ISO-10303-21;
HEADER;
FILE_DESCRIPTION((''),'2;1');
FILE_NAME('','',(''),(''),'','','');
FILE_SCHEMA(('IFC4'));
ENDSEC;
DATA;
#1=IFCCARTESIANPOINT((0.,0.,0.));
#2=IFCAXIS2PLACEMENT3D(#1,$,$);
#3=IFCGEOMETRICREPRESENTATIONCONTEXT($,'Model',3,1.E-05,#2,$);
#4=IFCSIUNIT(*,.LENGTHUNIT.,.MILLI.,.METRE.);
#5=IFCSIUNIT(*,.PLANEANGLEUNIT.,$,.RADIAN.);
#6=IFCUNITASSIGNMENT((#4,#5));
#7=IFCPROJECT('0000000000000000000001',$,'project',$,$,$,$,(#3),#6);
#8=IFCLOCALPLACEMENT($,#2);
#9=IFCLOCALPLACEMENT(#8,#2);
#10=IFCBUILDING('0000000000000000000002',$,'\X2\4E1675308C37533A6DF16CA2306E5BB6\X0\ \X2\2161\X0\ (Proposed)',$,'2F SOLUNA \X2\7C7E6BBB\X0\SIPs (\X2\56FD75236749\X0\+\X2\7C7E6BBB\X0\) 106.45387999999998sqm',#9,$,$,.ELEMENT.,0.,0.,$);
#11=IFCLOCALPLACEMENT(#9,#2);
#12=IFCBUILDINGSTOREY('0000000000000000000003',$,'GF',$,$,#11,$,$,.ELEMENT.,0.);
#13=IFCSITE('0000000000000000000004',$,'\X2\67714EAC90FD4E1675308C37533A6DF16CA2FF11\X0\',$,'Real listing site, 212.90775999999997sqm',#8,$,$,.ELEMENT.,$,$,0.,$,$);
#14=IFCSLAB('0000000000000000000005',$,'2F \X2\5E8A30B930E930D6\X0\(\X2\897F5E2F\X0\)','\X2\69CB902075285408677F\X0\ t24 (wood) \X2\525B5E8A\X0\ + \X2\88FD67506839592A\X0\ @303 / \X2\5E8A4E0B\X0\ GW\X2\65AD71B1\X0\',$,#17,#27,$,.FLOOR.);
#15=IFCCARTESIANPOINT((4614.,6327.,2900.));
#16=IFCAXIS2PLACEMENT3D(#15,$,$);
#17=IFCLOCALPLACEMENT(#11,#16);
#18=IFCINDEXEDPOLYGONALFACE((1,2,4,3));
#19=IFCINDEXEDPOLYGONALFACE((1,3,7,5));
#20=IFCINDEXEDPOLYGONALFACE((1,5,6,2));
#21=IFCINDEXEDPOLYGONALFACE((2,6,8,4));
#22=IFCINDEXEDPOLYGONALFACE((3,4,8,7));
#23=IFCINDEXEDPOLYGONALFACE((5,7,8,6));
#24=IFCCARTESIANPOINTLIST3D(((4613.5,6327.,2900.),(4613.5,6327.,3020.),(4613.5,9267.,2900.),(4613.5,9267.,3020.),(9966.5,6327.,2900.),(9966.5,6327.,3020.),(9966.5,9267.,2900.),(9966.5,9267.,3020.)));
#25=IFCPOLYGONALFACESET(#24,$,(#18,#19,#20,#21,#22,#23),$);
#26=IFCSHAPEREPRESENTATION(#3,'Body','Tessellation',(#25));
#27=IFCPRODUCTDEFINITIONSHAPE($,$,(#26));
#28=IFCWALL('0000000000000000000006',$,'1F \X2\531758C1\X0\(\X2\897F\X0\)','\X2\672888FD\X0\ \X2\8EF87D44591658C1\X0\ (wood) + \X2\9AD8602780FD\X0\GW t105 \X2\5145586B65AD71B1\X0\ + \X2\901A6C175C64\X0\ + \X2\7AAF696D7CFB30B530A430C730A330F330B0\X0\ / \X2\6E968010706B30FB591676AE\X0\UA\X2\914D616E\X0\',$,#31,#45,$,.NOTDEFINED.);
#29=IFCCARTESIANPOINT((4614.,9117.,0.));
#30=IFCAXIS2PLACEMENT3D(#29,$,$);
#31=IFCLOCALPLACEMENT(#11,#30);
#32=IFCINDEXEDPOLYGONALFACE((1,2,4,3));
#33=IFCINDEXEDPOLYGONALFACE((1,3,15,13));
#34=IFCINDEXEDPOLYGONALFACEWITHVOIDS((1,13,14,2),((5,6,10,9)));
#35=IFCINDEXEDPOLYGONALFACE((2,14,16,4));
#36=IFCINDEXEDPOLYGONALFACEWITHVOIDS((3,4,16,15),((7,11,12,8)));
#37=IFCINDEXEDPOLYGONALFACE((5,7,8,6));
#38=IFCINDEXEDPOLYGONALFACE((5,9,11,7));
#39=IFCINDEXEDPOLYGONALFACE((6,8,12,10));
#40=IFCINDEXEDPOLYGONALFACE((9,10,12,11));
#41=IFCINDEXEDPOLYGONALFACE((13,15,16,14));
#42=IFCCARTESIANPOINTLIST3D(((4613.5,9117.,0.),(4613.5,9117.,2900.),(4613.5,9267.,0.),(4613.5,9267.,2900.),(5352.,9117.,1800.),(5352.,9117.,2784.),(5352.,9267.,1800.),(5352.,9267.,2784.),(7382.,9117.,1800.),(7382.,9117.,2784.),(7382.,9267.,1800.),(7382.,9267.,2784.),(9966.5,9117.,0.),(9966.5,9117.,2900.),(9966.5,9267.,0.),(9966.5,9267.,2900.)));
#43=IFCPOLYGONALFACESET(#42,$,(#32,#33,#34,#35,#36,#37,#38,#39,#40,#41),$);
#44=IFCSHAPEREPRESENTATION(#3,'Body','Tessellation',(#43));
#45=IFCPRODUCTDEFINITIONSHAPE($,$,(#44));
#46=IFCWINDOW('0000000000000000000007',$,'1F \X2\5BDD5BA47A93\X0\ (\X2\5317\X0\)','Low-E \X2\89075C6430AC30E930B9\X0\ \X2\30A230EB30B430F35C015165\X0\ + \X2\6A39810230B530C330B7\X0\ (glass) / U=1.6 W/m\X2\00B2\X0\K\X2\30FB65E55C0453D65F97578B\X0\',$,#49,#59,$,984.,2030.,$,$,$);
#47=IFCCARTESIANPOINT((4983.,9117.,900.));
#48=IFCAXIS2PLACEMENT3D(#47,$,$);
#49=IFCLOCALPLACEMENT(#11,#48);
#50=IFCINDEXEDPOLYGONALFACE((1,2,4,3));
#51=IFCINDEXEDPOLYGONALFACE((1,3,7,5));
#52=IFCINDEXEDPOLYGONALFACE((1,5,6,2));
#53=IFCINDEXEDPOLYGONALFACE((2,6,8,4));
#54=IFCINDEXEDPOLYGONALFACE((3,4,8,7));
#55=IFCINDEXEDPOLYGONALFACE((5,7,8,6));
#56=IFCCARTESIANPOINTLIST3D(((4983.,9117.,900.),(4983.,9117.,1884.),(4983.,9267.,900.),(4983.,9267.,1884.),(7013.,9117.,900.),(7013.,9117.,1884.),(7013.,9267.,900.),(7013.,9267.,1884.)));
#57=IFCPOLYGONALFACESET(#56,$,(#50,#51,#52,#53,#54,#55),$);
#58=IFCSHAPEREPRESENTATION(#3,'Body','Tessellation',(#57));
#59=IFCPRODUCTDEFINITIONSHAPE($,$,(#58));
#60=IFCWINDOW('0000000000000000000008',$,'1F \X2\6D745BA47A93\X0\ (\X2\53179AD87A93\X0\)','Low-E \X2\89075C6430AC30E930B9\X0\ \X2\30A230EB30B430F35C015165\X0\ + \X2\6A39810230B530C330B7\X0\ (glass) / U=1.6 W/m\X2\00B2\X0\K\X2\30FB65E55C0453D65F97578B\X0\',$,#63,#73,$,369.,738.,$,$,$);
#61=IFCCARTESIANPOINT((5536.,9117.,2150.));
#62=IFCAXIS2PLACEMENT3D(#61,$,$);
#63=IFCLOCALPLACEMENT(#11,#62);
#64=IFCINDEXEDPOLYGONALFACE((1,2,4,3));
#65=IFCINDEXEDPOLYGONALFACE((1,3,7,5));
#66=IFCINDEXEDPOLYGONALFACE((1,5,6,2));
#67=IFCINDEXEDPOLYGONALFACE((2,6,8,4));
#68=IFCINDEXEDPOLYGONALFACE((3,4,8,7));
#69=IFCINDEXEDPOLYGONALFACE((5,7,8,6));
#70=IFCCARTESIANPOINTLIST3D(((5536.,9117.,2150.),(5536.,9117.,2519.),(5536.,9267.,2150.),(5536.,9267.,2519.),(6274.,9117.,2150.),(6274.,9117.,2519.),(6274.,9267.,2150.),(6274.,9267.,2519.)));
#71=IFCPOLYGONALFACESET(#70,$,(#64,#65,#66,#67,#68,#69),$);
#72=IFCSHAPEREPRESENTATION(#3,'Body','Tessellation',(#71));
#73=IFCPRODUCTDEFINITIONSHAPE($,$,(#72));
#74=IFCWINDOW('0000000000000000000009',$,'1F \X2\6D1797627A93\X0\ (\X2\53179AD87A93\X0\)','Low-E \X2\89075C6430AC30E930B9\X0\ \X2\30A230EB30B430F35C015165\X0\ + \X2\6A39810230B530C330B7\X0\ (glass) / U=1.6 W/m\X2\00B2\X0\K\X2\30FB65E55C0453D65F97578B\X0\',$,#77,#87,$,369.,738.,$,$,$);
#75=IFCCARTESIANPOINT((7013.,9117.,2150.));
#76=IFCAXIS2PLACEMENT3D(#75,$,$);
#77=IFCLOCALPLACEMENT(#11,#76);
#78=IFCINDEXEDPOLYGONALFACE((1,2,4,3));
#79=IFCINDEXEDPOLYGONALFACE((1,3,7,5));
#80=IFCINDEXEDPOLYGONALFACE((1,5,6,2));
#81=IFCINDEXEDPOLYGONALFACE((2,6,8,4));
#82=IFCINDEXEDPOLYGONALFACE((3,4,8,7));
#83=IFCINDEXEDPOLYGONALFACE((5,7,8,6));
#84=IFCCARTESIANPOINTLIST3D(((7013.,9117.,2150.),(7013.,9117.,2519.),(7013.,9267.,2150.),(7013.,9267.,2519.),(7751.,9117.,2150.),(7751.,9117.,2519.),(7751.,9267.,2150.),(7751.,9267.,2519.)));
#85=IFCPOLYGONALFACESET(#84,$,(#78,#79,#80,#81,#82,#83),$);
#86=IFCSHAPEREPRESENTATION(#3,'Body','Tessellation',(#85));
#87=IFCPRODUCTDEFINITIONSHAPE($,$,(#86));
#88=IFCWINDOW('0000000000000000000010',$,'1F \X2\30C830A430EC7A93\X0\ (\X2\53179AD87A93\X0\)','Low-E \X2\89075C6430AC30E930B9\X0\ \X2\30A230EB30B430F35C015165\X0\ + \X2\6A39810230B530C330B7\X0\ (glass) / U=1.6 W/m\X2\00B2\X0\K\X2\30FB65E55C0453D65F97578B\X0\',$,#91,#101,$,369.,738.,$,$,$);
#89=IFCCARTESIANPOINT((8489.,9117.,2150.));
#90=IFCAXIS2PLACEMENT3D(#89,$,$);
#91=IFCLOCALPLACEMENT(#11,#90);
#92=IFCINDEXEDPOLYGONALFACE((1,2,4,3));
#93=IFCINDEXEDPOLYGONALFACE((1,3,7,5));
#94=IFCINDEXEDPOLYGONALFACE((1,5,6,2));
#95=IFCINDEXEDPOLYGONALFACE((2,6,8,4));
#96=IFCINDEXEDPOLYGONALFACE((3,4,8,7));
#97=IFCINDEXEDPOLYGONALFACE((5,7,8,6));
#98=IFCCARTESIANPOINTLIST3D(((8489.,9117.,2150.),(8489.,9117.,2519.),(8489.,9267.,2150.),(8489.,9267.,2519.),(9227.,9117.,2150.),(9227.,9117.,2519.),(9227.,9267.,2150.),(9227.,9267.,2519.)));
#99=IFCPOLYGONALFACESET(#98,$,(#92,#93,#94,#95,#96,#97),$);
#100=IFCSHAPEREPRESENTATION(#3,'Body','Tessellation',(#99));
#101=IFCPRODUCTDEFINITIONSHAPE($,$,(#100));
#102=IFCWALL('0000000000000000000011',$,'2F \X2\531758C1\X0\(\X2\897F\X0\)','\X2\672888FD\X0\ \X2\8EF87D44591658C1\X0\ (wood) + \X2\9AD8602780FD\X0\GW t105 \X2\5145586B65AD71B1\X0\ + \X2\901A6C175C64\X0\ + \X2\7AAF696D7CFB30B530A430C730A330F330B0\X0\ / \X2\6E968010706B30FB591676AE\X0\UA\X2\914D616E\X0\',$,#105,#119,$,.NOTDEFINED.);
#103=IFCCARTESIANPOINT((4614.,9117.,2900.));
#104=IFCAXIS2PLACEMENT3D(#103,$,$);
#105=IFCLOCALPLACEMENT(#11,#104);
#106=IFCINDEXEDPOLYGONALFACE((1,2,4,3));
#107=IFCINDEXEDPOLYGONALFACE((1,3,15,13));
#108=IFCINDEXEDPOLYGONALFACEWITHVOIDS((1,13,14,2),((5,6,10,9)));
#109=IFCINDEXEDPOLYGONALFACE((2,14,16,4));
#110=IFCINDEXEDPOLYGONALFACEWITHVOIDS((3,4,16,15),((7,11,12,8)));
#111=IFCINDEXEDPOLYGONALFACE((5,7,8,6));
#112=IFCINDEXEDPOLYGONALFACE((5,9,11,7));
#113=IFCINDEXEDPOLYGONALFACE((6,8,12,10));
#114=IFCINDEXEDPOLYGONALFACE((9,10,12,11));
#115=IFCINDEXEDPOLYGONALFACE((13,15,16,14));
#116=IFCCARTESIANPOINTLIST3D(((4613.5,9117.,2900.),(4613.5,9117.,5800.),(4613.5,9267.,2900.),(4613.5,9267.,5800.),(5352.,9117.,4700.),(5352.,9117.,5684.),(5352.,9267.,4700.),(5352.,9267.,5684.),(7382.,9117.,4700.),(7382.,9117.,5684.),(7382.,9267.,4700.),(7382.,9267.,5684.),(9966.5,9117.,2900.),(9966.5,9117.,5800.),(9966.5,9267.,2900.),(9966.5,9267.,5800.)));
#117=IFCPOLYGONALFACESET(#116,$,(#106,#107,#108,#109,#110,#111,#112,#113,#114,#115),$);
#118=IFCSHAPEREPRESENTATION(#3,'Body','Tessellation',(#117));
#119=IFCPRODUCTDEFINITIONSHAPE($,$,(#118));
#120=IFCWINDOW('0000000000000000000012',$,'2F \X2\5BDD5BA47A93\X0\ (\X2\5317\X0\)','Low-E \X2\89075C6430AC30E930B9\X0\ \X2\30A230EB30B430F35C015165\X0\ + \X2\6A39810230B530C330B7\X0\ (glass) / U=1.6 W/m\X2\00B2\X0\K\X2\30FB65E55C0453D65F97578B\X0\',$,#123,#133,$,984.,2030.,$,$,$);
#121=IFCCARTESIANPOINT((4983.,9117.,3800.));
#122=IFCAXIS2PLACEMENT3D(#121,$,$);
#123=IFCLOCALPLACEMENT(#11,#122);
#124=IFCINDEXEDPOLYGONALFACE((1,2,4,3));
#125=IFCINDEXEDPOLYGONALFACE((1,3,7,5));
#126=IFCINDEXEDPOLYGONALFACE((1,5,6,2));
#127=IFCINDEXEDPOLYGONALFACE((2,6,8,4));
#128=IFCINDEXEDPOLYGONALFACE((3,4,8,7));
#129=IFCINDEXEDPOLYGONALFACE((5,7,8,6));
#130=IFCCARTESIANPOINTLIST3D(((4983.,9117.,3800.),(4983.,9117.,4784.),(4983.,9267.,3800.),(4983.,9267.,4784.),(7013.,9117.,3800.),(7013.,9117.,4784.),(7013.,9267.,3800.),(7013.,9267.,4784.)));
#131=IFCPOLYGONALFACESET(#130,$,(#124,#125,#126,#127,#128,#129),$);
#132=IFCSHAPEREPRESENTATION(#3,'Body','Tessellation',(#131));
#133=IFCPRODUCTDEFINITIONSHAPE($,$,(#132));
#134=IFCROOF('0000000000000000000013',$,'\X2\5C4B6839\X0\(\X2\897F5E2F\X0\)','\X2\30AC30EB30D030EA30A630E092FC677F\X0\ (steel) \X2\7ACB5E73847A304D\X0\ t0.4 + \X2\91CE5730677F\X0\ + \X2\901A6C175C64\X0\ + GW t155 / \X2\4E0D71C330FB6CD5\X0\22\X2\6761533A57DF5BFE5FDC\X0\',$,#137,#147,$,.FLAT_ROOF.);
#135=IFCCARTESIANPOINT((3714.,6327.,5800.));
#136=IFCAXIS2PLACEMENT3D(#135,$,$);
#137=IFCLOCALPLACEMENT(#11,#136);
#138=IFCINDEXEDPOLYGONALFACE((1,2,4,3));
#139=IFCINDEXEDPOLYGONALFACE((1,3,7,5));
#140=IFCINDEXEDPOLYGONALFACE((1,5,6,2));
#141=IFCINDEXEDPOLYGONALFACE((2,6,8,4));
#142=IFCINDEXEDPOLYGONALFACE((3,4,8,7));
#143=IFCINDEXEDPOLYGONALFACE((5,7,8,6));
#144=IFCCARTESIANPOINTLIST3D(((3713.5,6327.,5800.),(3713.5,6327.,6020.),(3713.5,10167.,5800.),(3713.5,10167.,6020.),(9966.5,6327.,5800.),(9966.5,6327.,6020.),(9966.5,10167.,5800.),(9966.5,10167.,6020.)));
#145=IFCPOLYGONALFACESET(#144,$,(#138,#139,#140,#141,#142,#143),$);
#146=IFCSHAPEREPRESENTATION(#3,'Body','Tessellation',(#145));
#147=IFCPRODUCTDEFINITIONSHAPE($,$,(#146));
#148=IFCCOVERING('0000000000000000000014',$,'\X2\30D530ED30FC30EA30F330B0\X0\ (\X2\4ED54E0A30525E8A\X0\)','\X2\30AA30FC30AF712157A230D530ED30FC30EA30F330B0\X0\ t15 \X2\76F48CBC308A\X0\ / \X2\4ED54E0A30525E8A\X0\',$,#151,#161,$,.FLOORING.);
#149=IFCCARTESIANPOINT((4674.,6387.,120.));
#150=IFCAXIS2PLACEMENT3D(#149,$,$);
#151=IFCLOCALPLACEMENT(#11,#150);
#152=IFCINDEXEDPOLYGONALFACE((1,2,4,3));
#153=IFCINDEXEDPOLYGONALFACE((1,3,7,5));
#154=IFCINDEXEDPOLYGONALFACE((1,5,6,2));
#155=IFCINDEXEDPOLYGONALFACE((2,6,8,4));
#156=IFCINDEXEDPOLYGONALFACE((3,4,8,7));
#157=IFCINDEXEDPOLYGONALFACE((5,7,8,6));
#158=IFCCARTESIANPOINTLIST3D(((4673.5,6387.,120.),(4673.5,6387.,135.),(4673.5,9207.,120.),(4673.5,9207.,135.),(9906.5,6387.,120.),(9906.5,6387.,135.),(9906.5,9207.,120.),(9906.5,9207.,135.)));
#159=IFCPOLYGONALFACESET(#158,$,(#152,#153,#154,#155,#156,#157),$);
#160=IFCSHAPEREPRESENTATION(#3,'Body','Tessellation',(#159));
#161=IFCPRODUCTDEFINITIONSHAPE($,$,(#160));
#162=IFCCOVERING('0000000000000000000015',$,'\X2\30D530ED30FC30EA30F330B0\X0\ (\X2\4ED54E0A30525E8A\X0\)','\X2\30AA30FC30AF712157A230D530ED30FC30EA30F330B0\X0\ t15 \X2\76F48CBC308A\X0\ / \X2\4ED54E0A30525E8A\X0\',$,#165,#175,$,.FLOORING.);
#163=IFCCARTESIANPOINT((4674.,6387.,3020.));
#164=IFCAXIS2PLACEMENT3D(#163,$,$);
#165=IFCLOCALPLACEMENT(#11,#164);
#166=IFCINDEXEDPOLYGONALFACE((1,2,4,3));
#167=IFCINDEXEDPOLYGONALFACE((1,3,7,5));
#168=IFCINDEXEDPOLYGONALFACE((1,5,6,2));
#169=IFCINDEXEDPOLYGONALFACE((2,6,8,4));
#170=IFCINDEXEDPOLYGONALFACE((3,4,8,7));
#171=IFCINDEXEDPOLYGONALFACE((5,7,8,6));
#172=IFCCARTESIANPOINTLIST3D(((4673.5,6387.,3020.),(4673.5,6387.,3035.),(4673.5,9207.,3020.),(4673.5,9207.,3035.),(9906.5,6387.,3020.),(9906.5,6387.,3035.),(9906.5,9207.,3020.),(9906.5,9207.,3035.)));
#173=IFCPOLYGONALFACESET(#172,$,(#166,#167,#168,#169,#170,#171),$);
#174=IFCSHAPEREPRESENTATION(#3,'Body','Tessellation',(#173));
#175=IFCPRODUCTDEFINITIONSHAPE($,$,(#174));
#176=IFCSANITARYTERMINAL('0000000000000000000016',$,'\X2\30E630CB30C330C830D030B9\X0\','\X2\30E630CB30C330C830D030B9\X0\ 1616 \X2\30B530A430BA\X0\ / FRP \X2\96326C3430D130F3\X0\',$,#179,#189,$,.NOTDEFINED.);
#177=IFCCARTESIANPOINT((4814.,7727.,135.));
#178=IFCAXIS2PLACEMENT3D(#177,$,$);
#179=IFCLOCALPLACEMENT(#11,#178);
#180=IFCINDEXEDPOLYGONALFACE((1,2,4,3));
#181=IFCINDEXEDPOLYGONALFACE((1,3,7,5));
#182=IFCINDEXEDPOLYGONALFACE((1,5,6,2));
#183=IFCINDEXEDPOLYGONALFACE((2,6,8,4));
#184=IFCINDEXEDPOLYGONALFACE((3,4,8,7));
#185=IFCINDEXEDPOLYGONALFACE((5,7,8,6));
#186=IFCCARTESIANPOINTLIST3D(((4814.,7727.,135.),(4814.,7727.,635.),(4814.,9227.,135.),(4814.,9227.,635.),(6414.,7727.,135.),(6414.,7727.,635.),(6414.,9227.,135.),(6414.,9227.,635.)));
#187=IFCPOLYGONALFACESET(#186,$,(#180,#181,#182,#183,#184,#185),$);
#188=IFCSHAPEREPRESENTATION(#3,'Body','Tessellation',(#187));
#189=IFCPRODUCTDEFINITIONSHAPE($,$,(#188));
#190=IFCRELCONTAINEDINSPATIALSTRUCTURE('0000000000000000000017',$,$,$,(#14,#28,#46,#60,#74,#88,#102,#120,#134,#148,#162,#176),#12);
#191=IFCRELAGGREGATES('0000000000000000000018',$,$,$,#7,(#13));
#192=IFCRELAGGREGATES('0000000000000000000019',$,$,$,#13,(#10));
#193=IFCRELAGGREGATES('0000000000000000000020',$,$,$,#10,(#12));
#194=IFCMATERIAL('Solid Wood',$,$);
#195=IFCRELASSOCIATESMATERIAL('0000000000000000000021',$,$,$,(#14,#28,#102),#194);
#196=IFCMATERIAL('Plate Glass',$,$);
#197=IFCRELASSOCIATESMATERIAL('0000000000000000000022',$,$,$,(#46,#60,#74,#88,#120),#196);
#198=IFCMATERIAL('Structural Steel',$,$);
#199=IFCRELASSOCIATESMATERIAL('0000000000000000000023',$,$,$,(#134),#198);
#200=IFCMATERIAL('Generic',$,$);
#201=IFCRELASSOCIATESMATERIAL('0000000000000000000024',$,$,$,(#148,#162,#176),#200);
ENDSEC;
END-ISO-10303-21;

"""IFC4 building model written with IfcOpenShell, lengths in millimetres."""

from ifc_helpers import new_model, si_unit, frame, frame_2d, origin, place, context, project, spatial, rectangle, extrude, material, element, fill, save


model = new_model("IFC4")

# Units and contexts
model_context = context("Model", 3, precision=1e-05, world=origin())
ifc_project = project(units=[si_unit("LENGTHUNIT", "METRE", prefix="MILLI"), si_unit("PLANEANGLEUNIT", "RADIAN")], contexts=[model_context])

# Site, building, storey
site_placement = place(None, origin())
site = spatial("IfcSite", under=ifc_project, at=site_placement, Name="東京都世田谷区深沢１", ObjectType="Real listing site, 212.90775999999997sqm", CompositionType="ELEMENT", RefElevation=0.0)
building_placement = place(site_placement, origin())
building = spatial("IfcBuilding", under=site, at=building_placement, Name="世田谷区深沢の家 Ⅱ (Proposed)", ObjectType="2F SOLUNA 籾殻SIPs (国産杉+籾殻) 106.45387999999998sqm", CompositionType="ELEMENT", ElevationOfRefHeight=0.0, ElevationOfTerrain=0.0)
storey_placement = place(building_placement, origin())
storey = spatial("IfcBuildingStorey", under=building, at=storey_placement, Name="GF", CompositionType="ELEMENT", Elevation=0.0)

# Slab
ifc_material_1 = material(Name="Solid Wood")
slab_1_placement = place(storey_placement, frame((4614.0, 6327.0, 2900.0)))
element("IfcSlab", 1, at=slab_1_placement, inside=storey, material=ifc_material_1, Name="2F 床スラブ(西帯)", Description="構造用合板 t24 (wood) 剛床 + 製材根太 @303 / 床下 GW断熱", PredefinedType="FLOOR", context=model_context, shape_type="SweptSolid", body=[
    extrude(rectangle(XDim=5353.0, YDim=2940.0, at=frame_2d((2676.0, 1470.0))), frame((4614.0, 6327.0, 2900.0)), (0.0, 0.0, 1.0), 120.0),
])

# Wall, openings, windows
wall_1_placement = place(storey_placement, frame((4614.0, 9117.0, 0.0)))
wall_1 = element("IfcWall", 2, at=wall_1_placement, inside=storey, material=ifc_material_1, Name="1F 北壁(西)", Description="木製 軸組外壁 (wood) + 高性能GW t105 充填断熱 + 通気層 + 窯業系サイディング / 準耐火・外皮UA配慮", PredefinedType="NOTDEFINED", context=model_context, shape_type="SweptSolid", body=[
    extrude(rectangle(XDim=5353.0, YDim=150.0, at=frame_2d((2676.0, 75.0))), frame((4614.0, 9117.0, 0.0)), (0.0, 0.0, 1.0), 2900.0),
])
opening_1_placement = place(storey_placement, frame((4983.0, 9117.0, 900.0)))
opening_1 = element("IfcOpeningElement", 3, at=opening_1_placement, cuts=wall_1, PredefinedType="NOTDEFINED", context=model_context, shape_type="SweptSolid", body=[
    extrude(rectangle(XDim=2030.0, YDim=150.0, at=frame_2d((1015.0, 75.0))), frame((4983.0, 9117.0, 900.0)), (0.0, 0.0, 1.0), 984.0),
])
opening_2_placement = place(storey_placement, frame((5536.0, 9117.0, 2150.0)))
opening_2 = element("IfcOpeningElement", 4, at=opening_2_placement, cuts=wall_1, PredefinedType="NOTDEFINED", context=model_context, shape_type="SweptSolid", body=[
    extrude(rectangle(XDim=738.0, YDim=150.0, at=frame_2d((369.0, 75.0))), frame((5536.0, 9117.0, 2150.0)), (0.0, 0.0, 1.0), 369.0),
])
opening_3_placement = place(storey_placement, frame((7013.0, 9117.0, 2150.0)))
opening_3 = element("IfcOpeningElement", 5, at=opening_3_placement, cuts=wall_1, PredefinedType="NOTDEFINED", context=model_context, shape_type="SweptSolid", body=[
    extrude(rectangle(XDim=738.0, YDim=150.0, at=frame_2d((369.0, 75.0))), frame((7013.0, 9117.0, 2150.0)), (0.0, 0.0, 1.0), 369.0),
])
opening_4_placement = place(storey_placement, frame((8489.0, 9117.0, 2150.0)))
opening_4 = element("IfcOpeningElement", 6, at=opening_4_placement, cuts=wall_1, PredefinedType="NOTDEFINED", context=model_context, shape_type="SweptSolid", body=[
    extrude(rectangle(XDim=738.0, YDim=150.0, at=frame_2d((369.0, 75.0))), frame((8489.0, 9117.0, 2150.0)), (0.0, 0.0, 1.0), 369.0),
])
ifc_material_2 = material(Name="Plate Glass")
window_1_placement = place(storey_placement, frame((4983.0, 9117.0, 900.0)))
window_1 = element("IfcWindow", 7, at=window_1_placement, inside=storey, material=ifc_material_2, Name="1F 寝室窓 (北)", Description="Low-E 複層ガラス アルゴン封入 + 樹脂サッシ (glass) / U=1.6 W/m²K・日射取得型", OverallHeight=984.0, OverallWidth=2030.0, context=model_context, shape_type="SweptSolid", body=[
    extrude(rectangle(XDim=2030.0, YDim=150.0, at=frame_2d((1015.0, 75.0))), frame((4983.0, 9117.0, 900.0)), (0.0, 0.0, 1.0), 984.0),
])
fill(opening_1, window_1)
window_2_placement = place(storey_placement, frame((5536.0, 9117.0, 2150.0)))
window_2 = element("IfcWindow", 8, at=window_2_placement, inside=storey, material=ifc_material_2, Name="1F 浴室窓 (北高窓)", Description="Low-E 複層ガラス アルゴン封入 + 樹脂サッシ (glass) / U=1.6 W/m²K・日射取得型", OverallHeight=369.0, OverallWidth=738.0, context=model_context, shape_type="SweptSolid", body=[
    extrude(rectangle(XDim=738.0, YDim=150.0, at=frame_2d((369.0, 75.0))), frame((5536.0, 9117.0, 2150.0)), (0.0, 0.0, 1.0), 369.0),
])
fill(opening_2, window_2)
window_3_placement = place(storey_placement, frame((7013.0, 9117.0, 2150.0)))
window_3 = element("IfcWindow", 9, at=window_3_placement, inside=storey, material=ifc_material_2, Name="1F 洗面窓 (北高窓)", Description="Low-E 複層ガラス アルゴン封入 + 樹脂サッシ (glass) / U=1.6 W/m²K・日射取得型", OverallHeight=369.0, OverallWidth=738.0, context=model_context, shape_type="SweptSolid", body=[
    extrude(rectangle(XDim=738.0, YDim=150.0, at=frame_2d((369.0, 75.0))), frame((7013.0, 9117.0, 2150.0)), (0.0, 0.0, 1.0), 369.0),
])
fill(opening_3, window_3)
window_4_placement = place(storey_placement, frame((8489.0, 9117.0, 2150.0)))
window_4 = element("IfcWindow", 10, at=window_4_placement, inside=storey, material=ifc_material_2, Name="1F トイレ窓 (北高窓)", Description="Low-E 複層ガラス アルゴン封入 + 樹脂サッシ (glass) / U=1.6 W/m²K・日射取得型", OverallHeight=369.0, OverallWidth=738.0, context=model_context, shape_type="SweptSolid", body=[
    extrude(rectangle(XDim=738.0, YDim=150.0, at=frame_2d((369.0, 75.0))), frame((8489.0, 9117.0, 2150.0)), (0.0, 0.0, 1.0), 369.0),
])
fill(opening_4, window_4)

# Wall, opening, window
wall_2_placement = place(storey_placement, frame((4614.0, 9117.0, 2900.0)))
wall_2 = element("IfcWall", 11, at=wall_2_placement, inside=storey, material=ifc_material_1, Name="2F 北壁(西)", Description="木製 軸組外壁 (wood) + 高性能GW t105 充填断熱 + 通気層 + 窯業系サイディング / 準耐火・外皮UA配慮", PredefinedType="NOTDEFINED", context=model_context, shape_type="SweptSolid", body=[
    extrude(rectangle(XDim=5353.0, YDim=150.0, at=frame_2d((2676.0, 75.0))), frame((4614.0, 9117.0, 2900.0)), (0.0, 0.0, 1.0), 2900.0),
])
opening_5_placement = place(storey_placement, frame((4983.0, 9117.0, 3800.0)))
opening_5 = element("IfcOpeningElement", 12, at=opening_5_placement, cuts=wall_2, PredefinedType="NOTDEFINED", context=model_context, shape_type="SweptSolid", body=[
    extrude(rectangle(XDim=2030.0, YDim=150.0, at=frame_2d((1015.0, 75.0))), frame((4983.0, 9117.0, 3800.0)), (0.0, 0.0, 1.0), 984.0),
])
window_5_placement = place(storey_placement, frame((4983.0, 9117.0, 3800.0)))
window_5 = element("IfcWindow", 13, at=window_5_placement, inside=storey, material=ifc_material_2, Name="2F 寝室窓 (北)", Description="Low-E 複層ガラス アルゴン封入 + 樹脂サッシ (glass) / U=1.6 W/m²K・日射取得型", OverallHeight=984.0, OverallWidth=2030.0, context=model_context, shape_type="SweptSolid", body=[
    extrude(rectangle(XDim=2030.0, YDim=150.0, at=frame_2d((1015.0, 75.0))), frame((4983.0, 9117.0, 3800.0)), (0.0, 0.0, 1.0), 984.0),
])
fill(opening_5, window_5)

# Roof
ifc_material_3 = material(Name="Structural Steel")
for number, where, name in (
    (14, (3714.0, 6327.0, 5800.0), "屋根(西帯)"),
):
    element("IfcRoof", number, at=place(storey_placement, frame(where)), inside=storey, material=ifc_material_3, Name=name, Description="ガルバリウム鋼板 (steel) 立平葺き t0.4 + 野地板 + 通気層 + GW t155 / 不燃・法22条区域対応", PredefinedType="FLAT_ROOF", context=model_context, shape_type="SweptSolid", body=[
        extrude(rectangle(XDim=6253.0, YDim=3840.0, at=frame_2d((3126.0, 1920.0))), frame((3714.0, 6327.0, 5800.0)), (0.0, 0.0, 1.0), 220.0),
    ])

# Coverings
ifc_material_4 = material(Name="Generic")
covering_1_placement = place(storey_placement, frame((4674.0, 6387.0, 120.0)))
element("IfcCovering", 15, at=covering_1_placement, inside=storey, material=ifc_material_4, Name="フローリング (仕上げ床)", Description="オーク無垢フローリング t15 直貼り / 仕上げ床", PredefinedType="FLOORING", context=model_context, shape_type="SweptSolid", body=[
    extrude(rectangle(XDim=5233.0, YDim=2820.0, at=frame_2d((2616.0, 1410.0))), frame((4674.0, 6387.0, 120.0)), (0.0, 0.0, 1.0), 15.0),
])
covering_2_placement = place(storey_placement, frame((4674.0, 6387.0, 3020.0)))
element("IfcCovering", 16, at=covering_2_placement, inside=storey, material=ifc_material_4, Name="フローリング (仕上げ床)", Description="オーク無垢フローリング t15 直貼り / 仕上げ床", PredefinedType="FLOORING", context=model_context, shape_type="SweptSolid", body=[
    extrude(rectangle(XDim=5233.0, YDim=2820.0, at=frame_2d((2616.0, 1410.0))), frame((4674.0, 6387.0, 3020.0)), (0.0, 0.0, 1.0), 15.0),
])

# Sanitary terminal
sanitary_terminal_placement = place(storey_placement, frame((4814.0, 7727.0, 135.0)))
element("IfcSanitaryTerminal", 17, at=sanitary_terminal_placement, inside=storey, material=ifc_material_4, Name="ユニットバス", Description="ユニットバス 1616 サイズ / FRP 防水パン", PredefinedType="NOTDEFINED", context=model_context, shape_type="SweptSolid", body=[
    extrude(rectangle(XDim=1600.0, YDim=1500.0, at=frame_2d((800.0, 750.0))), frame((4814.0, 7727.0, 135.0)), (0.0, 0.0, 1.0), 500.0),
])

save(model, "model.ifc")
